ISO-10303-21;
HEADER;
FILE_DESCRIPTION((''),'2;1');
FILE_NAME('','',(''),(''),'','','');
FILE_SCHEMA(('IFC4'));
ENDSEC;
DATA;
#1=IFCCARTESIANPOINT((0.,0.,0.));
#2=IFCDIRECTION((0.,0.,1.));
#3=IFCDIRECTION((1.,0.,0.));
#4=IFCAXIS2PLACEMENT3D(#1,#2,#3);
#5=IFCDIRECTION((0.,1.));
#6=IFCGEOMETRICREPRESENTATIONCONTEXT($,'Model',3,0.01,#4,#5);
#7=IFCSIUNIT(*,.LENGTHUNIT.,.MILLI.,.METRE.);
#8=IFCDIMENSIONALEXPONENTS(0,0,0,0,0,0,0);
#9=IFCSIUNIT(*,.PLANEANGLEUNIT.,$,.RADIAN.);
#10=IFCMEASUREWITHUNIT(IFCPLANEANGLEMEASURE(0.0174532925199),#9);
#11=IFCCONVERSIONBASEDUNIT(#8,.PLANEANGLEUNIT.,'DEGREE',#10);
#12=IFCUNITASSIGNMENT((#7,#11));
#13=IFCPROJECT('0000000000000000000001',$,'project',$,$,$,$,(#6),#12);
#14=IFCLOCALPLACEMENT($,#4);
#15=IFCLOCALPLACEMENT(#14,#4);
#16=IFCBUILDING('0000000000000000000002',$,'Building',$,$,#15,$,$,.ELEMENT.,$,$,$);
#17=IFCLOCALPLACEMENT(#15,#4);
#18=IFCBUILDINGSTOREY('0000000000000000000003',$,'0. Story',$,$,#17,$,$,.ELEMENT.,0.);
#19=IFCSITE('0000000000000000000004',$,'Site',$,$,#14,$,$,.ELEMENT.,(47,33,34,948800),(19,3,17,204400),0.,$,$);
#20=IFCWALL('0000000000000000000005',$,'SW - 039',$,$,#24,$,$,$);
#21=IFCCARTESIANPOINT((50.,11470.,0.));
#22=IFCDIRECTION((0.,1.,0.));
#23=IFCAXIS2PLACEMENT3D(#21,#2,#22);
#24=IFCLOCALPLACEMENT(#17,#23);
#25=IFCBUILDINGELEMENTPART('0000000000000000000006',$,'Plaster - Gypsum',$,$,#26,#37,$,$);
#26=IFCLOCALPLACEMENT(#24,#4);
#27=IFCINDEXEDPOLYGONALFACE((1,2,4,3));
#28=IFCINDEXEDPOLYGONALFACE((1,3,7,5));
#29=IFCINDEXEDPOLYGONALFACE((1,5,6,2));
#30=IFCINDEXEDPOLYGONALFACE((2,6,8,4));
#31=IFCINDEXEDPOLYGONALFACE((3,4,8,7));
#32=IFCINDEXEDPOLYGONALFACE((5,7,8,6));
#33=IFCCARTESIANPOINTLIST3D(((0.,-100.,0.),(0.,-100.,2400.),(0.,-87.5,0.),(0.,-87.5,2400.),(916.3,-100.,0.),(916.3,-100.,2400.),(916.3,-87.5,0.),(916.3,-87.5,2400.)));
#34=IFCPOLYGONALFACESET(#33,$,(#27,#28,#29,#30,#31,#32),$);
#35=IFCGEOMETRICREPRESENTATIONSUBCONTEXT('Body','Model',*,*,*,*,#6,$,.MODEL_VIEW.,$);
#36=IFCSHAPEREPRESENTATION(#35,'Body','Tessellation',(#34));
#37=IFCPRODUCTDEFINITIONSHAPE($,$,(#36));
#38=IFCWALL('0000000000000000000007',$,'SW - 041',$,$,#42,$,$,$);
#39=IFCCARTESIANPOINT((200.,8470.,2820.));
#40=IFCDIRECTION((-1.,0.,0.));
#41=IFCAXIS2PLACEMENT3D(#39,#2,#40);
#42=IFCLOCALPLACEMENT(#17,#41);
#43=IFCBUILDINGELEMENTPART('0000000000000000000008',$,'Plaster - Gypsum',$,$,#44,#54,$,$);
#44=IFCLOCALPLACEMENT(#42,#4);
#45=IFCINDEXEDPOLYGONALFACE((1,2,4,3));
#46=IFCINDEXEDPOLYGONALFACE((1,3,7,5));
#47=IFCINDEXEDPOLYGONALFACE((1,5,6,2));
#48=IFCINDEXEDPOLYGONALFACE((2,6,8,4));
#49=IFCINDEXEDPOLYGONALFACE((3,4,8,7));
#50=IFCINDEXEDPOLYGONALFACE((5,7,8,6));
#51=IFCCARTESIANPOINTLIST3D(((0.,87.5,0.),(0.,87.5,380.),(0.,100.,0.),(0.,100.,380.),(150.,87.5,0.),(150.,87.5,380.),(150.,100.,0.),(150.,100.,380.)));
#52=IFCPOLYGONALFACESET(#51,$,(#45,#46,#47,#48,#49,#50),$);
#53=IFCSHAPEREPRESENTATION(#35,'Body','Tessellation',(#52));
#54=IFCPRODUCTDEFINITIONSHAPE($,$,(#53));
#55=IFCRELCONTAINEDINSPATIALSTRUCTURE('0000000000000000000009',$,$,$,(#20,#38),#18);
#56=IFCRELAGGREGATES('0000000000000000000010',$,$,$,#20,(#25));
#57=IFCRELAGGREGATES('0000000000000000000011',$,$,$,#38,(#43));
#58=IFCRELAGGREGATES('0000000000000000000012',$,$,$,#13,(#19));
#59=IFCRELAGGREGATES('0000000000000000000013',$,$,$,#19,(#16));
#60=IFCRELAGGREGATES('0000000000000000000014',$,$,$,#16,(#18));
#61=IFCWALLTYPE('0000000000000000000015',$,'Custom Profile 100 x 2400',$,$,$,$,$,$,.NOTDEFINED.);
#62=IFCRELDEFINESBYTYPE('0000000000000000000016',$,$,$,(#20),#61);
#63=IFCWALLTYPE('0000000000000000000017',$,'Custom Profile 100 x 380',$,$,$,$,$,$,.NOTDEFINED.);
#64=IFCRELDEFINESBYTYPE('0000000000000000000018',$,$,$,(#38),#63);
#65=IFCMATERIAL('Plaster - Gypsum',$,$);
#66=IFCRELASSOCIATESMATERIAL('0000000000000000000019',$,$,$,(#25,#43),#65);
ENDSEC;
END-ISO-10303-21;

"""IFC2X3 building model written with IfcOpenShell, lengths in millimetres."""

from ifc_helpers import new_model, entity, si_unit, converted_unit, direction, frame, origin_with_axes, place, context, subcontext, project, spatial, polyline, outline, extrude, material, type_object, element, aggregate, save


model = new_model("IFC2X3")

# Units and contexts
model_context = context("Model", 3, precision=0.01, world=origin_with_axes(), true_north=direction((0.0, 1.0)))
body_context = subcontext(model_context, "Body", "Model", "MODEL_VIEW")
ifc_project = project(units=[si_unit("LENGTHUNIT", "METRE", prefix="MILLI"), converted_unit("PLANEANGLEUNIT", "DEGREE", entity("IfcPlaneAngleMeasure", 0.0174532925199), si_unit("PLANEANGLEUNIT", "RADIAN"), dimensions=[0, 0, 0, 0, 0, 0, 0])], contexts=[model_context])

# Site, building, storey
site_placement = place(None, origin_with_axes())
site = spatial("IfcSite", under=ifc_project, at=site_placement, Name="Site", CompositionType="ELEMENT", RefLatitude=(47, 33, 34, 948800), RefLongitude=(19, 3, 17, 204400), RefElevation=0.0)
building_placement = place(site_placement, origin_with_axes())
building = spatial("IfcBuilding", under=site, at=building_placement, Name="Building", CompositionType="ELEMENT")
storey_placement = place(building_placement, origin_with_axes())
storey = spatial("IfcBuildingStorey", under=building, at=storey_placement, Name="0. Story", CompositionType="ELEMENT", Elevation=0.0)

# Shared definitions
ifc_material_1 = material(Name="Plaster - Gypsum")

# Shared definitions
wall_type_1 = type_object("IfcWallType", Name="Custom Profile 100 x 2400", PredefinedType="NOTDEFINED")

# Walls, building element parts
wall_1_placement = place(storey_placement, frame((50.0, 11470.0, 0.0), z_axis=(0.0, 0.0, 1.0), x_axis=(0.0, 1.0, 0.0)))
wall_1 = element("IfcWall", 1, at=wall_1_placement, inside=storey, type_object=wall_type_1, Name="SW - 039")
building_element_part_1_placement = place(wall_1_placement, origin_with_axes())
building_element_part_1 = element("IfcBuildingElementPart", 2, at=building_element_part_1_placement, material=ifc_material_1, Name="Plaster - Gypsum", context=body_context, shape_type="SweptSolid", body=[
    extrude(outline(polyline([(-100.0, 2400.0), (-100.0, 0.0), (-87.5, 0.0), (-87.5, 2400.0), (-100.0, 2400.0)])), frame((0.0, 0.0, 0.0), z_axis=(1.0, 0.0, 0.0), x_axis=(0.0, 1.0, 0.0)), (0.0, 0.0, 1.0), 916.3),
])
aggregate(wall_1, [building_element_part_1])
wall_type_2 = type_object("IfcWallType", Name="Custom Profile 100 x 380", PredefinedType="NOTDEFINED")
wall_2_placement = place(storey_placement, frame((200.0, 8470.0, 2820.0), z_axis=(0.0, 0.0, 1.0), x_axis=(-1.0, 0.0, 0.0)))
wall_2 = element("IfcWall", 3, at=wall_2_placement, inside=storey, type_object=wall_type_2, Name="SW - 041")
building_element_part_2_placement = place(wall_2_placement, origin_with_axes())
building_element_part_2 = element("IfcBuildingElementPart", 4, at=building_element_part_2_placement, material=ifc_material_1, Name="Plaster - Gypsum", context=body_context, shape_type="SweptSolid", body=[
    extrude(outline(polyline([(-100.0, 380.0), (-100.0, 0.0), (-87.5, 0.0), (-87.5, 380.0), (-100.0, 380.0)])), frame((0.0, 0.0, 0.0), z_axis=(-1.0, 0.0, 0.0), x_axis=(0.0, -1.0, 0.0)), (0.0, 0.0, -1.0), 150.0),
])
aggregate(wall_2, [building_element_part_2])

save(model, "model.ifc")
